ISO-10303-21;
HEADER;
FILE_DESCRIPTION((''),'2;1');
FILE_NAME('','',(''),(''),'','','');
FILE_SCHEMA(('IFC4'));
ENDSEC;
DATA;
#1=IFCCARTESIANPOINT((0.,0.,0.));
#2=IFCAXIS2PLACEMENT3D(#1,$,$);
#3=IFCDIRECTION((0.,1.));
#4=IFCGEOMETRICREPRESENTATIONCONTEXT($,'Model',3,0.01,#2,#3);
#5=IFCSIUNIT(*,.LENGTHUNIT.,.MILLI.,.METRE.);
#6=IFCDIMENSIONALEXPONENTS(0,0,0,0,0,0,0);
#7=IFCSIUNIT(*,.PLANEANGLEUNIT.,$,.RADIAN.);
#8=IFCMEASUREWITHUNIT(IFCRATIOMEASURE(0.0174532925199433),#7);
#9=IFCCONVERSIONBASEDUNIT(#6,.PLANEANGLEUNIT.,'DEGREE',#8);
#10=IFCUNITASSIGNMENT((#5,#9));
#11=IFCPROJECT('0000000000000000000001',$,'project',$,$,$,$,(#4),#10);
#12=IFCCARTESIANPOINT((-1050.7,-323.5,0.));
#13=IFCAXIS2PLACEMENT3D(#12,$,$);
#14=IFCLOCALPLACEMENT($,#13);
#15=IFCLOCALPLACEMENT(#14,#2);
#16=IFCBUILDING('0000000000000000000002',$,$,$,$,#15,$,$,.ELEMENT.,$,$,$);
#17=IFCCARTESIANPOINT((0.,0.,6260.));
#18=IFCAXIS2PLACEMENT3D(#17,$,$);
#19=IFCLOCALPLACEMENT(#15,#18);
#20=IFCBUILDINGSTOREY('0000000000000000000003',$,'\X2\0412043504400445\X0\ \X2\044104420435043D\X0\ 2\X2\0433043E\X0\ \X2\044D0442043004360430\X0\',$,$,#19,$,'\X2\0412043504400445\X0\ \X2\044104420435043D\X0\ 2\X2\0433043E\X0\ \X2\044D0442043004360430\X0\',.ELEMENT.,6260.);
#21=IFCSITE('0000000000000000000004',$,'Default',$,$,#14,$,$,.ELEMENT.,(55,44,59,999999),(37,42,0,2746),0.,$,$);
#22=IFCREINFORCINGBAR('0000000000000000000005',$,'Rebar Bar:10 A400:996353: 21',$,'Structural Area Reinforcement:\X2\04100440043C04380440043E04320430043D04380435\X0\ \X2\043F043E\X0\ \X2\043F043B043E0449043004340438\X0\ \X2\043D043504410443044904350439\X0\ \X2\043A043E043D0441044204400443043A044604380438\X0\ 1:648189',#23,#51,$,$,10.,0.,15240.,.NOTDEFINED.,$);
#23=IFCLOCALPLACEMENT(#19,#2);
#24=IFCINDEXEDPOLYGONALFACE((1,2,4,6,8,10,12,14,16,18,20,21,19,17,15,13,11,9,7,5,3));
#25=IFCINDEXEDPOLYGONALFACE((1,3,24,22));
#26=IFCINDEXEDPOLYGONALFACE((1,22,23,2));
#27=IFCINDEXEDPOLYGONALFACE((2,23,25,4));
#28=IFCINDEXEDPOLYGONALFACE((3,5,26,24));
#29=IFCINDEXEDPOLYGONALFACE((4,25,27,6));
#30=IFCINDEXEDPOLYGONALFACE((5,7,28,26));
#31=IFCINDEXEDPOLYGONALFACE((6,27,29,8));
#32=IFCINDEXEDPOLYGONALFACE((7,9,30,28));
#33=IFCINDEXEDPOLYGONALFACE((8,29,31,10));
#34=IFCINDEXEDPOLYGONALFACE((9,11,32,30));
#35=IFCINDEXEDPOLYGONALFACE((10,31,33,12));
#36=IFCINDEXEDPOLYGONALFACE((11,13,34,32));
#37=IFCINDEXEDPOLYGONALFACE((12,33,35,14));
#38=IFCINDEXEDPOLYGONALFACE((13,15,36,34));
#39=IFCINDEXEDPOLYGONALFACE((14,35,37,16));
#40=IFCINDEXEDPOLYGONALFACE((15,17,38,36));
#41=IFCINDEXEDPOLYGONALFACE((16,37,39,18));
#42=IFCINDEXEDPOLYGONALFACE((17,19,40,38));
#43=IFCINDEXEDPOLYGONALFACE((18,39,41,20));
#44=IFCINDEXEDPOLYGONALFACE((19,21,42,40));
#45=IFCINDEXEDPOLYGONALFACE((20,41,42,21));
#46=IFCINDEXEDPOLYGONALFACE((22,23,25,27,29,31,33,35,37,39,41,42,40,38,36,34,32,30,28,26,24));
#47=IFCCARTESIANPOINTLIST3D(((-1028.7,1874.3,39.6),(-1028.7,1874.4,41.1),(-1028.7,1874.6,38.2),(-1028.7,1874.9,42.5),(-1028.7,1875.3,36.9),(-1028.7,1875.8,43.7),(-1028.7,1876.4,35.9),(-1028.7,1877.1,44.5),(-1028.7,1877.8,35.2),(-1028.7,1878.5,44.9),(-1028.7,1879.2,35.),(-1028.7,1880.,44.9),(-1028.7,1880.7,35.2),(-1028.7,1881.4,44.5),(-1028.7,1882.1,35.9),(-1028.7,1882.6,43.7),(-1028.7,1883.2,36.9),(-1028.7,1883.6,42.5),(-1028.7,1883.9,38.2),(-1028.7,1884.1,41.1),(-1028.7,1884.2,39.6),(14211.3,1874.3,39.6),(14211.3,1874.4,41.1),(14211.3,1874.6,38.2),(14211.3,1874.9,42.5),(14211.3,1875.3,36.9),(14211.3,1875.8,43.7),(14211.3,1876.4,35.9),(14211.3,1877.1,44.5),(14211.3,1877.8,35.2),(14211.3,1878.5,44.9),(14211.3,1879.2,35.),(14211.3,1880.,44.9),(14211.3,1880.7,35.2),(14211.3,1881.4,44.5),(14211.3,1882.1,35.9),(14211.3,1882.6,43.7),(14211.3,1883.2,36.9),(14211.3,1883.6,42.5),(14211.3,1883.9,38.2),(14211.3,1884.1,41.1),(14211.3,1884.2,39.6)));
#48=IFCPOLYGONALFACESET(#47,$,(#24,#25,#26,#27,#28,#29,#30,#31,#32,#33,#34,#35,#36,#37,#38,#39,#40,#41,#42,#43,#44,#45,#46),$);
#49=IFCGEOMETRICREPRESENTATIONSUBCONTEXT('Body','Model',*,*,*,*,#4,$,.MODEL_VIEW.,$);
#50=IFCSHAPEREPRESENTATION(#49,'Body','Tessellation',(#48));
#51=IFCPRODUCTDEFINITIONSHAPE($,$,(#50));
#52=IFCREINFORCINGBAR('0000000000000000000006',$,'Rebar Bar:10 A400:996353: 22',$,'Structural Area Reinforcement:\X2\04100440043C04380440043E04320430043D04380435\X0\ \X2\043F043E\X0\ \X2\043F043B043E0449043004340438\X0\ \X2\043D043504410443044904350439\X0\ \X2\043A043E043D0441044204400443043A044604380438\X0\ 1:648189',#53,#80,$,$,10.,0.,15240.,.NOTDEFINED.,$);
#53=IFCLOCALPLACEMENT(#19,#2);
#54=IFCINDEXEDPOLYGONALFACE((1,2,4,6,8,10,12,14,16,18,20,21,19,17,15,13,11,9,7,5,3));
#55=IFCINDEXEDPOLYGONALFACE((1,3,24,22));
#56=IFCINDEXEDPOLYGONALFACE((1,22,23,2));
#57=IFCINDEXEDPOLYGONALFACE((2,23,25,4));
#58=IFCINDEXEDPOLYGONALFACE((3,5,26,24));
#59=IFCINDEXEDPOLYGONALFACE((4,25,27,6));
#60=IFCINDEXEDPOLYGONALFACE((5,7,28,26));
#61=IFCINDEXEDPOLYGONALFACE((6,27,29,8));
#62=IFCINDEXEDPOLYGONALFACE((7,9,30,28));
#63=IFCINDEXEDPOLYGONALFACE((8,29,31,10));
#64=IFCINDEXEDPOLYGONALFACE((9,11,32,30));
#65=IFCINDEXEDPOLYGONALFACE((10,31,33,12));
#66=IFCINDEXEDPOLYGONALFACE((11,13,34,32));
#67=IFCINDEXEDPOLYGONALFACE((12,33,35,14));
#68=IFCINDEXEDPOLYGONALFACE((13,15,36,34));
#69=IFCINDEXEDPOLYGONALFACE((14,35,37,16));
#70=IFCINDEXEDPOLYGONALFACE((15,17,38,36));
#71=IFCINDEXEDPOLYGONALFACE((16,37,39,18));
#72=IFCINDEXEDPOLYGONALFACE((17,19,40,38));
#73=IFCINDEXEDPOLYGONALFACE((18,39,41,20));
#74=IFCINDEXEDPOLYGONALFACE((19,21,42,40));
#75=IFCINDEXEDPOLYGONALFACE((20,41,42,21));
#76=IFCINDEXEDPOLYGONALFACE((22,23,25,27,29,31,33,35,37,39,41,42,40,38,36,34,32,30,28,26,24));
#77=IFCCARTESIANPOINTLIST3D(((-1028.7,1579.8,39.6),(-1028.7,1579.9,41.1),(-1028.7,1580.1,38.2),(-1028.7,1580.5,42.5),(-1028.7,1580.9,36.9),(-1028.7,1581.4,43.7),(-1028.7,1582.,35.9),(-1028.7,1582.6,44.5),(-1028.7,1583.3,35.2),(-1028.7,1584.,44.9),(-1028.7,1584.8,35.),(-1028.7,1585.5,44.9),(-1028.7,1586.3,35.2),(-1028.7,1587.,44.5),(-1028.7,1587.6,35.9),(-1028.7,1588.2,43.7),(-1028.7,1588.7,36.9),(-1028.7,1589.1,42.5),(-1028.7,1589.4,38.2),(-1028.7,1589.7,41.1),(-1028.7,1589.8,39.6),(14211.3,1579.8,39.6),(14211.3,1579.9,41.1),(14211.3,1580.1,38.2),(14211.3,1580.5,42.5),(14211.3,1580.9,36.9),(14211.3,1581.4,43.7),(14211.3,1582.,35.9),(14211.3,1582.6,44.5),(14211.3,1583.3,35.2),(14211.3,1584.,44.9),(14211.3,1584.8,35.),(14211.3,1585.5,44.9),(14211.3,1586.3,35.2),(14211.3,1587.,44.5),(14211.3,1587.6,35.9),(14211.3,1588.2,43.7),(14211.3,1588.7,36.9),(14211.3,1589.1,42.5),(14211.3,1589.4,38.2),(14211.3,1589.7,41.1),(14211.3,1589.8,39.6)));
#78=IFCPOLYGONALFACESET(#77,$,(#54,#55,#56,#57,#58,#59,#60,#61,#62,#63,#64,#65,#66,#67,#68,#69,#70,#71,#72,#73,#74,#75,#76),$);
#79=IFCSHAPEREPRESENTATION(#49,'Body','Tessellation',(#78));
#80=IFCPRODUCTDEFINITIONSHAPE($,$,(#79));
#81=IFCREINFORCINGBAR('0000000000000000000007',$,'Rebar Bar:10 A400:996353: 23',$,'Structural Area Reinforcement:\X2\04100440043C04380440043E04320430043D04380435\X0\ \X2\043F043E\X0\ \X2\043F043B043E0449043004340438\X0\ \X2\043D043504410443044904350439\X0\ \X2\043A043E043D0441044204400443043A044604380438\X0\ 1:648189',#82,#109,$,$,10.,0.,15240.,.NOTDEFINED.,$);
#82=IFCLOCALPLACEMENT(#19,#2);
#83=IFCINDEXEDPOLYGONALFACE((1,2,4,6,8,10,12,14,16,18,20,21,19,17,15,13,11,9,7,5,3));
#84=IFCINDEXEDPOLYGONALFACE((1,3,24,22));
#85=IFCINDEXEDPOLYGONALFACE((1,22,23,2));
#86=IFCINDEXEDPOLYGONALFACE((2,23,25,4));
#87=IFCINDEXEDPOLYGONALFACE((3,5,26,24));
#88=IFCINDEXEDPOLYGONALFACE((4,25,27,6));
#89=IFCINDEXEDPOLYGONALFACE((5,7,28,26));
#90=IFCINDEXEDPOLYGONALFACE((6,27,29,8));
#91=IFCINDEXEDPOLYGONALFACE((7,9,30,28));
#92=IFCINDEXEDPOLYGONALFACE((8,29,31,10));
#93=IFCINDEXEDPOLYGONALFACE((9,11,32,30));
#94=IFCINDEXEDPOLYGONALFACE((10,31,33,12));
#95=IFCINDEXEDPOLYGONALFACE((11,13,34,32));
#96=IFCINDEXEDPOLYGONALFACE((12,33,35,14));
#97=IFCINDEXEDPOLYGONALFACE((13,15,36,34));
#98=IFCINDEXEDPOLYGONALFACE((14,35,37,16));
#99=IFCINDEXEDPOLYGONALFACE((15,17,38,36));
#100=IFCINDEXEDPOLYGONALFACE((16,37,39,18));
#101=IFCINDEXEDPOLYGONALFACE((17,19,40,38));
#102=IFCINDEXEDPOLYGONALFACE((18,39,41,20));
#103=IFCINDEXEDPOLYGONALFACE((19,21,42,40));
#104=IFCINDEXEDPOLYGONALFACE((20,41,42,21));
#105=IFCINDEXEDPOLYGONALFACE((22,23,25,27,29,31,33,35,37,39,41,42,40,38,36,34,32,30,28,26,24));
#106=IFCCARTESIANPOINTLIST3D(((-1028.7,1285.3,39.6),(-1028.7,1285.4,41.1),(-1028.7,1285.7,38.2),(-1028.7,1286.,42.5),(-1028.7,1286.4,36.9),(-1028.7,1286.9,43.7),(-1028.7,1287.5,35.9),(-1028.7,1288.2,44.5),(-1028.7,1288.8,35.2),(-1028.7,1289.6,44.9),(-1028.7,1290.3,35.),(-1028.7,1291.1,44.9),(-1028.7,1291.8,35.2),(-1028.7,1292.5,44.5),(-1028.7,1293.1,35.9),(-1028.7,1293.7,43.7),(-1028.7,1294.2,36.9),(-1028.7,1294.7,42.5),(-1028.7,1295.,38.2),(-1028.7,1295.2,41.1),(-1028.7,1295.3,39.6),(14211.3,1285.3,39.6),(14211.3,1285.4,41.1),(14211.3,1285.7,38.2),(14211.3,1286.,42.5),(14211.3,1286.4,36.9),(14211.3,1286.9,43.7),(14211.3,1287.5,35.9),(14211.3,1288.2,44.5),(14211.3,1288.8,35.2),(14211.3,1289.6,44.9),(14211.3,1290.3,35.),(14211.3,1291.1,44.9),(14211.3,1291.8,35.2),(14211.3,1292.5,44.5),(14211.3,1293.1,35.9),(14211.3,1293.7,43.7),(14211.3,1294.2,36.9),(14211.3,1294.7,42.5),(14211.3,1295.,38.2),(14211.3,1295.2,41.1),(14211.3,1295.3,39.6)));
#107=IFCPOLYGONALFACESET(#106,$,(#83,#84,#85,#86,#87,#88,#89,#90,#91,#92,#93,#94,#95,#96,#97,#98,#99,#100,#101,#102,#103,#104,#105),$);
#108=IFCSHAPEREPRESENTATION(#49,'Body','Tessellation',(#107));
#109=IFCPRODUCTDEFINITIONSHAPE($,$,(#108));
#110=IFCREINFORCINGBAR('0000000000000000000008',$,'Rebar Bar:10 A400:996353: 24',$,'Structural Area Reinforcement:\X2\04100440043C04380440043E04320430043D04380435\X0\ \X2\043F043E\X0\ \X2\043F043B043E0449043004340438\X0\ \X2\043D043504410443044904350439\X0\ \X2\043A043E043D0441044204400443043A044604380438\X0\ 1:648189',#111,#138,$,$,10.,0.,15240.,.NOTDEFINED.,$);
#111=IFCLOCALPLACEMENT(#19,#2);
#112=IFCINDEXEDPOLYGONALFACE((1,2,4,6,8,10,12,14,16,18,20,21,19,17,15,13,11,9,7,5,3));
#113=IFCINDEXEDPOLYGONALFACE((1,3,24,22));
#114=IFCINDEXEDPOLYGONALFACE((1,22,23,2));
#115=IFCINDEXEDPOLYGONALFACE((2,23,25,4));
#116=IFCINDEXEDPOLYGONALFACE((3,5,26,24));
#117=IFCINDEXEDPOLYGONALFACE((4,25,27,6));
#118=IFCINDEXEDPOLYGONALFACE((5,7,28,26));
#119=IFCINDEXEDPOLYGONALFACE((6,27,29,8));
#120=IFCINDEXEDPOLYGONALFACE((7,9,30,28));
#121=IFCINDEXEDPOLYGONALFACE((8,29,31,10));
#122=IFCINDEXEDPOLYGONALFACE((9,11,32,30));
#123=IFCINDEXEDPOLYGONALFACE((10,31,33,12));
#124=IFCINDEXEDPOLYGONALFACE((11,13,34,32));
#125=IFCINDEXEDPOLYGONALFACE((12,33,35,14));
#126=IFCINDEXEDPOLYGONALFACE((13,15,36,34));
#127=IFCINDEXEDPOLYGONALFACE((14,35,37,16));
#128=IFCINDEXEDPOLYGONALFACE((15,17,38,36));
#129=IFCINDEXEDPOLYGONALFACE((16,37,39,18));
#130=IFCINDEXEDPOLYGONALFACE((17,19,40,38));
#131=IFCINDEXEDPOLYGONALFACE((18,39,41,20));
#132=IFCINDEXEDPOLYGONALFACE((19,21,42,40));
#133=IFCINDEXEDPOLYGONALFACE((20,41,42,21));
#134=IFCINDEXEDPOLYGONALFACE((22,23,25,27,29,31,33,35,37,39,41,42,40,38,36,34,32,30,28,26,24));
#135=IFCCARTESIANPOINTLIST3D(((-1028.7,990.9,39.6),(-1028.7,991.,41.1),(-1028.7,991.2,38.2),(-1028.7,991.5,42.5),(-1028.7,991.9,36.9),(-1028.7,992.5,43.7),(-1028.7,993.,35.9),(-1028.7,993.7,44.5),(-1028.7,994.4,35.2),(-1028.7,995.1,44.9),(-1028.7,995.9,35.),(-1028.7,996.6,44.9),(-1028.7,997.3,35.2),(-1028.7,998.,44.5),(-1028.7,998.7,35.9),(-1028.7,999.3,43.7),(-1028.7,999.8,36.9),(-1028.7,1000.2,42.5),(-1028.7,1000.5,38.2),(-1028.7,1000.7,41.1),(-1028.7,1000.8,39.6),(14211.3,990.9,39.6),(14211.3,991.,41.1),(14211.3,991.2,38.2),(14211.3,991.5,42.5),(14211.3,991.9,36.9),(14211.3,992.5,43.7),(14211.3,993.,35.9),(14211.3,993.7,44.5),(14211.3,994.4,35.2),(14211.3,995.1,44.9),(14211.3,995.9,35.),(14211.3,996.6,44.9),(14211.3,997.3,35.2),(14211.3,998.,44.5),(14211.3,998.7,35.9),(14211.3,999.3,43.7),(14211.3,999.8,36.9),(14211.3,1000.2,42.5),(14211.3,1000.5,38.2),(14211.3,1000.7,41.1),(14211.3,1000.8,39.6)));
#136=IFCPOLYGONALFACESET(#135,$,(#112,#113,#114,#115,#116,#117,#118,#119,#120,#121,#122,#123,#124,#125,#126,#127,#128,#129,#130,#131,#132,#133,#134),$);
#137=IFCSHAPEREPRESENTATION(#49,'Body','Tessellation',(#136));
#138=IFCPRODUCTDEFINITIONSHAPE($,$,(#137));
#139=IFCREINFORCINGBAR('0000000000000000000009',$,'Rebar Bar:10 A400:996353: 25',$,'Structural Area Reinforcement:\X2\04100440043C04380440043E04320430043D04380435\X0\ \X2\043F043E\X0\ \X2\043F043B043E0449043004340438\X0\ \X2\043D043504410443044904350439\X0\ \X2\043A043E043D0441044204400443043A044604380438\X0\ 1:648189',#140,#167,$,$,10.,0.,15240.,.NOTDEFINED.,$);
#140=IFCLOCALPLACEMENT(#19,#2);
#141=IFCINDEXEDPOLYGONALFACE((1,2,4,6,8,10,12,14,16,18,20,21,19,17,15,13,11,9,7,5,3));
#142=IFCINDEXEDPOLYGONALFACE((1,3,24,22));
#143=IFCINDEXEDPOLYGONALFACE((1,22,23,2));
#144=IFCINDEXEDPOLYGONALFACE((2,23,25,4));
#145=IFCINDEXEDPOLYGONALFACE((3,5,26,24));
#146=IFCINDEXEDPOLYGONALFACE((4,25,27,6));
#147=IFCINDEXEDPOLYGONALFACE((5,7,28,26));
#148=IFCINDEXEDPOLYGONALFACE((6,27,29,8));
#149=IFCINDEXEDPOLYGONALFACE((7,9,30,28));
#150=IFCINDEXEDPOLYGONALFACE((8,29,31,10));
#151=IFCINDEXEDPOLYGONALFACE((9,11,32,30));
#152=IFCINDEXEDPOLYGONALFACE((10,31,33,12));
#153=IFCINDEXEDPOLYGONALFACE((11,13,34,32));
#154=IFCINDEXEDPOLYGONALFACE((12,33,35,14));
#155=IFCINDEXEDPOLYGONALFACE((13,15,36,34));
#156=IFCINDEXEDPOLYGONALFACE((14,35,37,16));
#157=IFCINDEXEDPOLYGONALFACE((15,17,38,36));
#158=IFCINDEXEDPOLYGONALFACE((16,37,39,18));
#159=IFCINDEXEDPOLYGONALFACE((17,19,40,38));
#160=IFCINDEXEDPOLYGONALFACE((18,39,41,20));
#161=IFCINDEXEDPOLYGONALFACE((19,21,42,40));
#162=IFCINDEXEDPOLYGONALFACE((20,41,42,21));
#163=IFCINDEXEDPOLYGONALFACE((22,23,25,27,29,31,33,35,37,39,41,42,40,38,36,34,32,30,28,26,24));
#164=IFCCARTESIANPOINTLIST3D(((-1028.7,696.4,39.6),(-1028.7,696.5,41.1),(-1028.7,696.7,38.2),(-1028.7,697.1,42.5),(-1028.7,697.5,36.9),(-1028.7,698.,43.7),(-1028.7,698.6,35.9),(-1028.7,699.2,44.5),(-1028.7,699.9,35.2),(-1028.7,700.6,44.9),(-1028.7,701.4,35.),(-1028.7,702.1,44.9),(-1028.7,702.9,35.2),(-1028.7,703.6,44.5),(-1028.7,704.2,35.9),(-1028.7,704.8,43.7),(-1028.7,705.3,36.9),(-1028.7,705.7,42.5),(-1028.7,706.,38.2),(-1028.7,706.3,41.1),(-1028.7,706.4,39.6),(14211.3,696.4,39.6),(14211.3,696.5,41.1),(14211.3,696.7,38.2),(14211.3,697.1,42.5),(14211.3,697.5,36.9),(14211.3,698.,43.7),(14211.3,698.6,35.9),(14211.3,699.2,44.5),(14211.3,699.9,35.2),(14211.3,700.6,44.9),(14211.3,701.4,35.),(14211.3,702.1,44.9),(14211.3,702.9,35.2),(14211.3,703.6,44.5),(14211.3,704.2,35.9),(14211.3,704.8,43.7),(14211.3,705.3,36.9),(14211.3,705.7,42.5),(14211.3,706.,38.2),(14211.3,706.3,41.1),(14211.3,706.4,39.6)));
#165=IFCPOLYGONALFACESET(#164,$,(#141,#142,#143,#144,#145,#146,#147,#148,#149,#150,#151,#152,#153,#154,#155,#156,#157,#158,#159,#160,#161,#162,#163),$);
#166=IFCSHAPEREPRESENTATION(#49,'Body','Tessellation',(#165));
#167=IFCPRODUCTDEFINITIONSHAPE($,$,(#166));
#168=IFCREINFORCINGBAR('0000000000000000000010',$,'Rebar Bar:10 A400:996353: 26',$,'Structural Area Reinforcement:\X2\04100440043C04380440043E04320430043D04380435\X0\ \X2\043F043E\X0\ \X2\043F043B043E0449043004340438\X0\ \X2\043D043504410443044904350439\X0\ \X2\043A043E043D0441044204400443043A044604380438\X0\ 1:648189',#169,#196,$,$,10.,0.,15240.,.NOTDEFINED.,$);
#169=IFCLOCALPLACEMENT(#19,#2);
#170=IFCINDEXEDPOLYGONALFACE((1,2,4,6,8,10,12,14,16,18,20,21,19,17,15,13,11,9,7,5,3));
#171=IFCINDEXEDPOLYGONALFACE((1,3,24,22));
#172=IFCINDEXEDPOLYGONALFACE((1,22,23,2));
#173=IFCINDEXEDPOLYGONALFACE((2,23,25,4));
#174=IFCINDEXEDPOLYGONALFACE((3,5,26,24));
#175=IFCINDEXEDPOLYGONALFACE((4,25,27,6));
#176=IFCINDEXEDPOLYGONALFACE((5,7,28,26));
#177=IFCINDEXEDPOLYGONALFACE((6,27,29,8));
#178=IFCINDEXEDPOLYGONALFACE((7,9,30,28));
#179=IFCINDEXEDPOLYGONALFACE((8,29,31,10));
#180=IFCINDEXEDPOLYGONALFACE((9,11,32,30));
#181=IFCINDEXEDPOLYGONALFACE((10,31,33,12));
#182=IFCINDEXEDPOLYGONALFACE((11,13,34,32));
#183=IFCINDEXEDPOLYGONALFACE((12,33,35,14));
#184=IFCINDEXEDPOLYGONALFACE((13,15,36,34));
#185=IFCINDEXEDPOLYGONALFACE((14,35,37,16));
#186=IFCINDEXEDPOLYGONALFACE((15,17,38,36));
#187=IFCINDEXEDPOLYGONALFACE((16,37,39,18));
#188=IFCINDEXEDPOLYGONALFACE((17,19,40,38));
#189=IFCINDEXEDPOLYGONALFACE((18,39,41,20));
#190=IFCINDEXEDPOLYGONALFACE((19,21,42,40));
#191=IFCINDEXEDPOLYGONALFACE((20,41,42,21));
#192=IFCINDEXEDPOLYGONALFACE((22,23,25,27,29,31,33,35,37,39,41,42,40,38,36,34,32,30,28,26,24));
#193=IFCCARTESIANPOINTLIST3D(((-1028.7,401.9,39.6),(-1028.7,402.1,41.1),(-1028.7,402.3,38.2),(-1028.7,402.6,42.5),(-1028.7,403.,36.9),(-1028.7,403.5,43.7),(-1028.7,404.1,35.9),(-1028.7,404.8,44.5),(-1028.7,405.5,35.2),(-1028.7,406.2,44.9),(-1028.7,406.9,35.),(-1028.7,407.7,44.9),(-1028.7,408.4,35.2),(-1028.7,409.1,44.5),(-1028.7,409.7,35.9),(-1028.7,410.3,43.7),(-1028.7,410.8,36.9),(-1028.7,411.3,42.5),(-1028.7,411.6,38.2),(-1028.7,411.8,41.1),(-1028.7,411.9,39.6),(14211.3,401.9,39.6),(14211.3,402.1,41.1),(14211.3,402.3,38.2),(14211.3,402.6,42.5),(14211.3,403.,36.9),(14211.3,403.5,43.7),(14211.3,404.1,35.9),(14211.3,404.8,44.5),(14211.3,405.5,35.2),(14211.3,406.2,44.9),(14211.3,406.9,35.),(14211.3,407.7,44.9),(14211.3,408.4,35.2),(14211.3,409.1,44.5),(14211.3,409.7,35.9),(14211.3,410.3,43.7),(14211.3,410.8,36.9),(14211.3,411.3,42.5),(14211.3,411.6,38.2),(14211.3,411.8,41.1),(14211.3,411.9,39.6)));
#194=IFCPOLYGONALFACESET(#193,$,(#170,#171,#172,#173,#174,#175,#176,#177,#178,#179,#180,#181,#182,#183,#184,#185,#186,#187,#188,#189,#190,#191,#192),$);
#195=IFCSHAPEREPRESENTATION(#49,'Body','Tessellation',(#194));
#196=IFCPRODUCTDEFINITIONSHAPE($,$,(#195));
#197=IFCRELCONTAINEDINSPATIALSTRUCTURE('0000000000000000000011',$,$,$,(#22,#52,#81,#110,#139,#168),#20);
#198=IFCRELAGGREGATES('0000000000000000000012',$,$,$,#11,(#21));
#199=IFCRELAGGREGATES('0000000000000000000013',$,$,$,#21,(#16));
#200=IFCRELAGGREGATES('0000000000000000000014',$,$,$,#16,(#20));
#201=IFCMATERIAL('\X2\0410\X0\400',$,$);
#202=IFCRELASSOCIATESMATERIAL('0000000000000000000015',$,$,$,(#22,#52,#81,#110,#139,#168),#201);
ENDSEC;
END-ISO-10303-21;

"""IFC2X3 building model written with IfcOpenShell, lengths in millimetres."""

from ifc_helpers import new_model, entity, si_unit, converted_unit, direction, frame, origin, place, context, subcontext, project, spatial, material, element, save


model = new_model("IFC2X3")

# Units and contexts
model_context = context("Model", 3, precision=0.01, world=origin(), true_north=direction((0.0, 1.0)))
body_context = subcontext(model_context, "Body", "Model", "MODEL_VIEW")
ifc_project = project(units=[si_unit("LENGTHUNIT", "METRE", prefix="MILLI"), converted_unit("PLANEANGLEUNIT", "DEGREE", entity("IfcRatioMeasure", 0.0174532925199433), si_unit("PLANEANGLEUNIT", "RADIAN"), dimensions=[0, 0, 0, 0, 0, 0, 0])], contexts=[model_context])

# Site, building, storey
site_placement = place(None, frame((-1050.7, -323.5, 0.0)))
site = spatial("IfcSite", under=ifc_project, at=site_placement, Name="Default", CompositionType="ELEMENT", RefLatitude=(55, 44, 59, 999999), RefLongitude=(37, 42, 0, 2746), RefElevation=0.0)
building_placement = place(site_placement, origin())
building = spatial("IfcBuilding", under=site, at=building_placement, CompositionType="ELEMENT")
storey_placement = place(building_placement, frame((0.0, 0.0, 6260.0)))
storey = spatial("IfcBuildingStorey", under=building, at=storey_placement, Name="Верх стен 2го этажа", LongName="Верх стен 2го этажа", CompositionType="ELEMENT", Elevation=6260.0)

# Reinforcing bars
ifc_material = material(Name="А400")
reinforcing_bar_1_placement = place(storey_placement, origin())
element("IfcReinforcingBar", 1, at=reinforcing_bar_1_placement, inside=storey, material=ifc_material, Name="Rebar Bar:10 A400:996353: 21", ObjectType="Structural Area Reinforcement:Армирование по площади несущей конструкции 1:648189", BarLength=15240.0, BarRole="NOTDEFINED", CrossSectionArea=0.0, NominalDiameter=10.0, context=body_context, shape_type="AdvancedSweptSolid", body=[
    entity("IfcSweptDiskSolid", entity("IfcCompositeCurve", [entity("IfcCompositeCurveSegment", "CONTINUOUS", True, entity("IfcPolyline", [entity("IfcCartesianPoint", [14211.3, 1879.2, 40.0]), entity("IfcCartesianPoint", [-1028.7, 1879.2, 40.0])]))], False), 5.0, None, 0.0, 1.0),
])
reinforcing_bar_2_placement = place(storey_placement, origin())
element("IfcReinforcingBar", 2, at=reinforcing_bar_2_placement, inside=storey, material=ifc_material, Name="Rebar Bar:10 A400:996353: 22", ObjectType="Structural Area Reinforcement:Армирование по площади несущей конструкции 1:648189", BarLength=15240.0, BarRole="NOTDEFINED", CrossSectionArea=0.0, NominalDiameter=10.0, context=body_context, shape_type="AdvancedSweptSolid", body=[
    entity("IfcSweptDiskSolid", entity("IfcCompositeCurve", [entity("IfcCompositeCurveSegment", "CONTINUOUS", True, entity("IfcPolyline", [entity("IfcCartesianPoint", [14211.3, 1584.8, 40.0]), entity("IfcCartesianPoint", [-1028.7, 1584.8, 40.0])]))], False), 5.0, None, 0.0, 1.0),
])
reinforcing_bar_3_placement = place(storey_placement, origin())
element("IfcReinforcingBar", 3, at=reinforcing_bar_3_placement, inside=storey, material=ifc_material, Name="Rebar Bar:10 A400:996353: 23", ObjectType="Structural Area Reinforcement:Армирование по площади несущей конструкции 1:648189", BarLength=15240.0, BarRole="NOTDEFINED", CrossSectionArea=0.0, NominalDiameter=10.0, context=body_context, shape_type="AdvancedSweptSolid", body=[
    entity("IfcSweptDiskSolid", entity("IfcCompositeCurve", [entity("IfcCompositeCurveSegment", "CONTINUOUS", True, entity("IfcPolyline", [entity("IfcCartesianPoint", [14211.3, 1290.3, 40.0]), entity("IfcCartesianPoint", [-1028.7, 1290.3, 40.0])]))], False), 5.0, None, 0.0, 1.0),
])
reinforcing_bar_4_placement = place(storey_placement, origin())
element("IfcReinforcingBar", 4, at=reinforcing_bar_4_placement, inside=storey, material=ifc_material, Name="Rebar Bar:10 A400:996353: 24", ObjectType="Structural Area Reinforcement:Армирование по площади несущей конструкции 1:648189", BarLength=15240.0, BarRole="NOTDEFINED", CrossSectionArea=0.0, NominalDiameter=10.0, context=body_context, shape_type="AdvancedSweptSolid", body=[
    entity("IfcSweptDiskSolid", entity("IfcCompositeCurve", [entity("IfcCompositeCurveSegment", "CONTINUOUS", True, entity("IfcPolyline", [entity("IfcCartesianPoint", [14211.3, 995.9, 40.0]), entity("IfcCartesianPoint", [-1028.7, 995.9, 40.0])]))], False), 5.0, None, 0.0, 1.0),
])
reinforcing_bar_5_placement = place(storey_placement, origin())
element("IfcReinforcingBar", 5, at=reinforcing_bar_5_placement, inside=storey, material=ifc_material, Name="Rebar Bar:10 A400:996353: 25", ObjectType="Structural Area Reinforcement:Армирование по площади несущей конструкции 1:648189", BarLength=15240.0, BarRole="NOTDEFINED", CrossSectionArea=0.0, NominalDiameter=10.0, context=body_context, shape_type="AdvancedSweptSolid", body=[
    entity("IfcSweptDiskSolid", entity("IfcCompositeCurve", [entity("IfcCompositeCurveSegment", "CONTINUOUS", True, entity("IfcPolyline", [entity("IfcCartesianPoint", [14211.3, 701.4, 40.0]), entity("IfcCartesianPoint", [-1028.7, 701.4, 40.0])]))], False), 5.0, None, 0.0, 1.0),
])
reinforcing_bar_6_placement = place(storey_placement, origin())
element("IfcReinforcingBar", 6, at=reinforcing_bar_6_placement, inside=storey, material=ifc_material, Name="Rebar Bar:10 A400:996353: 26", ObjectType="Structural Area Reinforcement:Армирование по площади несущей конструкции 1:648189", BarLength=15240.0, BarRole="NOTDEFINED", CrossSectionArea=0.0, NominalDiameter=10.0, context=body_context, shape_type="AdvancedSweptSolid", body=[
    entity("IfcSweptDiskSolid", entity("IfcCompositeCurve", [entity("IfcCompositeCurveSegment", "CONTINUOUS", True, entity("IfcPolyline", [entity("IfcCartesianPoint", [14211.3, 406.9, 40.0]), entity("IfcCartesianPoint", [-1028.7, 406.9, 40.0])]))], False), 5.0, None, 0.0, 1.0),
])

save(model, "model.ifc")
